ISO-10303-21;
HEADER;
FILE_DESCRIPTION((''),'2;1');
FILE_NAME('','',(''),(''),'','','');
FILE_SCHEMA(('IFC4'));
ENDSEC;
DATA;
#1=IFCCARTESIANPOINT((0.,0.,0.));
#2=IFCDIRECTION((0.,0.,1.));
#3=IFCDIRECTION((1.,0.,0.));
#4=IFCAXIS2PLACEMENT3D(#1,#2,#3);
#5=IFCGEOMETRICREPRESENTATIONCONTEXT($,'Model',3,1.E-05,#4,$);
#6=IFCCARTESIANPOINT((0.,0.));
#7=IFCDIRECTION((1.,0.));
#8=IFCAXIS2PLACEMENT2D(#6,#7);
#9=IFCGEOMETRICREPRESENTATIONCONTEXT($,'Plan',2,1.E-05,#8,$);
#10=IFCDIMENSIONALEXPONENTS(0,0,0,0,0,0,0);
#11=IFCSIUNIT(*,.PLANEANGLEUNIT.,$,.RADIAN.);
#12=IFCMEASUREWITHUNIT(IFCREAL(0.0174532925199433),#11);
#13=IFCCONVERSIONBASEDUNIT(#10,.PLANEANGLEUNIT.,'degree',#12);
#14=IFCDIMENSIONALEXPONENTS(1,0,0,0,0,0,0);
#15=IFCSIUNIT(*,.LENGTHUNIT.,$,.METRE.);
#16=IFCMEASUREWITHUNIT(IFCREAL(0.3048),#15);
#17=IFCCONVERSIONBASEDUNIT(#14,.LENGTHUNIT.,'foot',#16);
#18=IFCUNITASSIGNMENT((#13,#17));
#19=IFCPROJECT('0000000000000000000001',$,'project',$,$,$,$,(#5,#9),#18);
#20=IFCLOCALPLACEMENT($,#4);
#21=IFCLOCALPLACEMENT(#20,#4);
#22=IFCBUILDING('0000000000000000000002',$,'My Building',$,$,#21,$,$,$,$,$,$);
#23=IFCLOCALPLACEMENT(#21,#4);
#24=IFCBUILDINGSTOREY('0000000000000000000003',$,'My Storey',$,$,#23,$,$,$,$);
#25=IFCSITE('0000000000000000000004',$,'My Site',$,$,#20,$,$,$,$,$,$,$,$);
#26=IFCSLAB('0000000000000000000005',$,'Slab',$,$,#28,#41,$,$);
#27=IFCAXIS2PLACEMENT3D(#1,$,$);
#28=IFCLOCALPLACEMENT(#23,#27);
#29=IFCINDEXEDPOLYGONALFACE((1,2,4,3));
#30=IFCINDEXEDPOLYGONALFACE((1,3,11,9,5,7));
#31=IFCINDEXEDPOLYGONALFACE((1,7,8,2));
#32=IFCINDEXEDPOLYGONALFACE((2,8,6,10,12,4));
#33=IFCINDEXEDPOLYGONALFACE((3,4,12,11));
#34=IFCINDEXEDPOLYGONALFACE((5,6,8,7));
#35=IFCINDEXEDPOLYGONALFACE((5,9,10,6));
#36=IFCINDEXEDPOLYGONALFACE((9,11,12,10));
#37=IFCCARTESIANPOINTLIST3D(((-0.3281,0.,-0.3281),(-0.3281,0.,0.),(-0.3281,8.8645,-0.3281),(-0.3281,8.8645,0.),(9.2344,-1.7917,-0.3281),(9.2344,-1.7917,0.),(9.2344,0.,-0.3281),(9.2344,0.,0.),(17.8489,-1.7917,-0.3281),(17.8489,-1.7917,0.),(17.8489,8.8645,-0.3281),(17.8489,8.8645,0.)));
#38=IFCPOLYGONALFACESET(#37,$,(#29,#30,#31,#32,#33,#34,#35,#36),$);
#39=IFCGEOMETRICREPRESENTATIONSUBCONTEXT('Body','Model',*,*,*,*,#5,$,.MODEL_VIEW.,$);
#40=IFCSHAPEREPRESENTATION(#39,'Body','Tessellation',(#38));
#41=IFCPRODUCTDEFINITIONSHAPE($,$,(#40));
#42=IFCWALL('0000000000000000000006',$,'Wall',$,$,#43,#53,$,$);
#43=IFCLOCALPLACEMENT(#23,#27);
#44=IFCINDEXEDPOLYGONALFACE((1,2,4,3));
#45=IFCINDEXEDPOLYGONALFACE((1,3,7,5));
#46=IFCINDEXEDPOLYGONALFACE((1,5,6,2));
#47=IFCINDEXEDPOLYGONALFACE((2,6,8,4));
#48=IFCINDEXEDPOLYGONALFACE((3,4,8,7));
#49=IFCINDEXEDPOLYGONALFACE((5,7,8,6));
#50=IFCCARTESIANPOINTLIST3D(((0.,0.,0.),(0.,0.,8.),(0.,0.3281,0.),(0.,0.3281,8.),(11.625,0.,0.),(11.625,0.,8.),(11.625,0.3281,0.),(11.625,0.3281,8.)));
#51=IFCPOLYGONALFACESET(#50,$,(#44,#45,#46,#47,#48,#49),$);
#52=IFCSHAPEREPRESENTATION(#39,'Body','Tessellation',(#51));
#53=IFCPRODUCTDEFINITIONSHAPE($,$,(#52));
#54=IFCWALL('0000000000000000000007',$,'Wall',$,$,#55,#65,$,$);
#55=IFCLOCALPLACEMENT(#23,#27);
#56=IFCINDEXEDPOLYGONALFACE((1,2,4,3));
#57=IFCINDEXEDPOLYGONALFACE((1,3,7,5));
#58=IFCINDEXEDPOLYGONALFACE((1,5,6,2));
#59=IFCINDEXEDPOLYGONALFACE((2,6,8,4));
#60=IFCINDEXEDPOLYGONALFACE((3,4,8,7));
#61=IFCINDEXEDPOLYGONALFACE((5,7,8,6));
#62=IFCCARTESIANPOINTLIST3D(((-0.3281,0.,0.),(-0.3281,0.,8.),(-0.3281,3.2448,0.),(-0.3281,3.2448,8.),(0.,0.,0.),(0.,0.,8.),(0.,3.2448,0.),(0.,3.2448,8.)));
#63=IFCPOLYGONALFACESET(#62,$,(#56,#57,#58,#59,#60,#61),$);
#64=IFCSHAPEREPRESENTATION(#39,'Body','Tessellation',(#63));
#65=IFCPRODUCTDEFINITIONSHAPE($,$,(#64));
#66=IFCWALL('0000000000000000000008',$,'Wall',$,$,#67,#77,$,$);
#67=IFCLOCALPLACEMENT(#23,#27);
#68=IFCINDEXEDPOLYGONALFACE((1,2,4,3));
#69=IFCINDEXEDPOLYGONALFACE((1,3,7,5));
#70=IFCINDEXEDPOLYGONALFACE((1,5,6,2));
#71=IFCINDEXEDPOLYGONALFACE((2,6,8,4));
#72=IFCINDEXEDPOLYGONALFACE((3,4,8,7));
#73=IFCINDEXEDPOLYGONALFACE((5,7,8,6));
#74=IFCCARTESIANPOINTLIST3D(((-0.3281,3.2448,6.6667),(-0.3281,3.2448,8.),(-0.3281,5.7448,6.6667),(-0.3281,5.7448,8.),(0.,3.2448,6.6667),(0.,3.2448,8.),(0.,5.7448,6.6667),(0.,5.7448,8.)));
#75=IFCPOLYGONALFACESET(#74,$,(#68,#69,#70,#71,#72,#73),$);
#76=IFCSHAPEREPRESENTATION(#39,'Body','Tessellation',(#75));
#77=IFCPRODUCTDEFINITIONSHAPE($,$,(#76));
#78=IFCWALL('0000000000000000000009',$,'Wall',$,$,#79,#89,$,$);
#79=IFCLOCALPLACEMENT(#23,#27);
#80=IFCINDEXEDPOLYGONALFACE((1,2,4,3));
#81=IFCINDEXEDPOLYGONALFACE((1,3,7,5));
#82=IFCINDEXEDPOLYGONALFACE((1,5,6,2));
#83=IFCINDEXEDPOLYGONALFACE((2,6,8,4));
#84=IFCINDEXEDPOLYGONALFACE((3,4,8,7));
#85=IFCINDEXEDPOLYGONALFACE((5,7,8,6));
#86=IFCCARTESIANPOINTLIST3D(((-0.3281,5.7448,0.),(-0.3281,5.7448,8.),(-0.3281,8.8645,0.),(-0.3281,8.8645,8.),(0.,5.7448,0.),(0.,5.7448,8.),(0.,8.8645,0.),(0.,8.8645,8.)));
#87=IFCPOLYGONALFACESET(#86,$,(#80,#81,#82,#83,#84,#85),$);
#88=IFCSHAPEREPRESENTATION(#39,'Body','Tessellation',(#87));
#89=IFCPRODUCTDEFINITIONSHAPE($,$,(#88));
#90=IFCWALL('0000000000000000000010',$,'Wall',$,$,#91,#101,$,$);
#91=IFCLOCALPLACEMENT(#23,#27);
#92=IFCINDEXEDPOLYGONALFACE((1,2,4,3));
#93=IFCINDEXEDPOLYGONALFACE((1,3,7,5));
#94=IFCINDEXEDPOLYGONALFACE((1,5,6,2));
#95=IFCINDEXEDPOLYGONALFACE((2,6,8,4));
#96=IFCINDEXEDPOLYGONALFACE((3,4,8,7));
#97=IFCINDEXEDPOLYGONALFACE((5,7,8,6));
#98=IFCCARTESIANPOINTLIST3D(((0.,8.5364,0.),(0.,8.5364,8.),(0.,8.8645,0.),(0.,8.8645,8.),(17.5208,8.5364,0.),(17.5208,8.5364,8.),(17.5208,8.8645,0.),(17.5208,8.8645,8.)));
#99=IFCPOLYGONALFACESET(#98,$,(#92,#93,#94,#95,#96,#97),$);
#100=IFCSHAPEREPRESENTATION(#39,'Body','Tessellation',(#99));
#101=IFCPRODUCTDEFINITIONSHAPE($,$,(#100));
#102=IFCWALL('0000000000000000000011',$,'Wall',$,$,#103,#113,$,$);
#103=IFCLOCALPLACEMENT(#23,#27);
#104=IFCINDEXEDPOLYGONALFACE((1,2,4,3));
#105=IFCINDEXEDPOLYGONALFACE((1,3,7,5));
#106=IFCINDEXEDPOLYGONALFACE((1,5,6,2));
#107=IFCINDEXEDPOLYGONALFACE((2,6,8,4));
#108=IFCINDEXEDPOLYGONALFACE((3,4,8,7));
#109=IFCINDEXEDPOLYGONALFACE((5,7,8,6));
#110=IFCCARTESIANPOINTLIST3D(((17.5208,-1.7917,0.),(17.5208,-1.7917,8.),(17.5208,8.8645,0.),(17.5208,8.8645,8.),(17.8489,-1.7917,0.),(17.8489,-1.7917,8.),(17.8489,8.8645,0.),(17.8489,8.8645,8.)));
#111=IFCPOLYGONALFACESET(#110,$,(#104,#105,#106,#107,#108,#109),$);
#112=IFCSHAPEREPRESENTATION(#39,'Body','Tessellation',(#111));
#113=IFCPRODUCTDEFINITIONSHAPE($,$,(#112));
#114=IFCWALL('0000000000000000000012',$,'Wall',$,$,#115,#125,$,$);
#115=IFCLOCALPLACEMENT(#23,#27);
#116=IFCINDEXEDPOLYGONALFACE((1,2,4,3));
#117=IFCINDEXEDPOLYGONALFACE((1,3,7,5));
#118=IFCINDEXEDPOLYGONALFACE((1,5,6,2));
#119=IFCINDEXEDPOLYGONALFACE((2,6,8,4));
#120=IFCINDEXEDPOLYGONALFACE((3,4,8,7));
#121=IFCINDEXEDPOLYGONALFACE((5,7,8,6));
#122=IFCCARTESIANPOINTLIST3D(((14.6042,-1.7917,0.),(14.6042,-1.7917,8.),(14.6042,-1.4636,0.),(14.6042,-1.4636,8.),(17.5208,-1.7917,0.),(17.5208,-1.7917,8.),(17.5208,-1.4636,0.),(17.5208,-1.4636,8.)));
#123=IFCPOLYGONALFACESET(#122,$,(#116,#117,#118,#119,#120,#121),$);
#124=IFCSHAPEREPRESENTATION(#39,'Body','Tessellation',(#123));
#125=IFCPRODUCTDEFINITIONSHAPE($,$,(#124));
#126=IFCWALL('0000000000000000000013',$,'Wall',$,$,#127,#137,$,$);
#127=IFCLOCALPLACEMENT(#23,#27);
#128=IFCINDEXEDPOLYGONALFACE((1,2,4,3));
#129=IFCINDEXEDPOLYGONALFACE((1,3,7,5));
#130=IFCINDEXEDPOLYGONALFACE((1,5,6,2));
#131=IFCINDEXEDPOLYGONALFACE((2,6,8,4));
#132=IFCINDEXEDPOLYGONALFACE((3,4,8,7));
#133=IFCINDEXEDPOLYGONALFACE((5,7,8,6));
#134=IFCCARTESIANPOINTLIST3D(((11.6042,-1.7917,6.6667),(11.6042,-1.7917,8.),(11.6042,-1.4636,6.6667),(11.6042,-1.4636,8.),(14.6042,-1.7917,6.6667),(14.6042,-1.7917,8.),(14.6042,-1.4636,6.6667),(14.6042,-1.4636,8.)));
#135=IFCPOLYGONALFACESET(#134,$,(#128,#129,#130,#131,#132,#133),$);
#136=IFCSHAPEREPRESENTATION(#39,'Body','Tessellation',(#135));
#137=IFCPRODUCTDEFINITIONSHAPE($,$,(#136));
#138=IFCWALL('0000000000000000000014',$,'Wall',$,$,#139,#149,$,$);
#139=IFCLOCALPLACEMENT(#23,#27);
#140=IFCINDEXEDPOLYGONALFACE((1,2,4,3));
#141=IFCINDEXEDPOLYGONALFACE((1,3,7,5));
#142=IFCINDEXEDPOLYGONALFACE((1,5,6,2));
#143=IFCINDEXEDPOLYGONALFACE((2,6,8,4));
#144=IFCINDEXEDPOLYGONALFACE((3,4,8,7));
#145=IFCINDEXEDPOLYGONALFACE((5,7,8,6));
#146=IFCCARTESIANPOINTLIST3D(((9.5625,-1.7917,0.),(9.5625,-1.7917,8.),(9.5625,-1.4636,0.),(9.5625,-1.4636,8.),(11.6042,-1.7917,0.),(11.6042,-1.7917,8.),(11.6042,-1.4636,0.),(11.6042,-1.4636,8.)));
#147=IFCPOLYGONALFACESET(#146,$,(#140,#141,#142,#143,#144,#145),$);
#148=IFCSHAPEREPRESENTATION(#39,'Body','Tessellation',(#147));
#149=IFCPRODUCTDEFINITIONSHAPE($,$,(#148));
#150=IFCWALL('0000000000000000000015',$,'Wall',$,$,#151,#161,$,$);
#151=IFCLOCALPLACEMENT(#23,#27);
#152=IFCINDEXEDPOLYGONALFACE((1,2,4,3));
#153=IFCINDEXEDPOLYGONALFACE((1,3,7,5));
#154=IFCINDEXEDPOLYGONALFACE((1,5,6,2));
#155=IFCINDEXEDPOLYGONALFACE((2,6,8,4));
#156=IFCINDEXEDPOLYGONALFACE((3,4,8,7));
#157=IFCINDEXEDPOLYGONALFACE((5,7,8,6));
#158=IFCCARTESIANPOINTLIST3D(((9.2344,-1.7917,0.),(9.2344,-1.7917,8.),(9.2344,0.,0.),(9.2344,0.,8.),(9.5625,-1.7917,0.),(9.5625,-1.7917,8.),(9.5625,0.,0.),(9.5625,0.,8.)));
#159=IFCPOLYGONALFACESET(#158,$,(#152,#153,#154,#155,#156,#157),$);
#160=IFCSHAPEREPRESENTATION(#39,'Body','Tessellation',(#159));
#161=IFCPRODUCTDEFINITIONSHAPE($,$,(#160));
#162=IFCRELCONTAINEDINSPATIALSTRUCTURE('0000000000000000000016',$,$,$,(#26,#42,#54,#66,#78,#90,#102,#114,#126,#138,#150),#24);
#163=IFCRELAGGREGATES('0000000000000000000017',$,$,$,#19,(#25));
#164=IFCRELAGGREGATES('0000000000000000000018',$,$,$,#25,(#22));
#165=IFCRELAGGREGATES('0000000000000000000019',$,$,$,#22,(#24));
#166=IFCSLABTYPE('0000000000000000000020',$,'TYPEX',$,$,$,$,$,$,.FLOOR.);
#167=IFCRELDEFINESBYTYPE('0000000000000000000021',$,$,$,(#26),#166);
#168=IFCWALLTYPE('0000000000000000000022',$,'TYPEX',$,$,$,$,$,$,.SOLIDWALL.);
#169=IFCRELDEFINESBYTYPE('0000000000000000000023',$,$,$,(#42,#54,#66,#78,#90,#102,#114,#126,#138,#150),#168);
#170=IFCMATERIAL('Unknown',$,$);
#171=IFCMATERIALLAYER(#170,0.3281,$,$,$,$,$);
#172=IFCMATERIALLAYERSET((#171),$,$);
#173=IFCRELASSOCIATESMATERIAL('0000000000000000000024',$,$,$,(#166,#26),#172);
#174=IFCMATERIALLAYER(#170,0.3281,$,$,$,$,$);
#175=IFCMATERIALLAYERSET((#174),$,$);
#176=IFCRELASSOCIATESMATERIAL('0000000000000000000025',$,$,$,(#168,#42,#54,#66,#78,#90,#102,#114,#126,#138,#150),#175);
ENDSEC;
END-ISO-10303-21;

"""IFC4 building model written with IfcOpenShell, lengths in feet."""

from ifc_helpers import new_model, entity, si_unit, converted_unit, frame, origin_with_axes, origin_2d_with_axis, place, context, subcontext, project, spatial, line, indexed_curve, outline, extrude, material, layer, layer_set, layer_usage, type_object, element, save


model = new_model("IFC4")

# Units and contexts
model_context = context("Model", 3, precision=1e-05, world=origin_with_axes())
plan_context = context("Plan", 2, precision=1e-05, world=origin_2d_with_axis())
body_context = subcontext(model_context, "Body", "Model", "MODEL_VIEW")
ifc_project = project(units=[converted_unit("PLANEANGLEUNIT", "degree", entity("IfcReal", 0.0174532925199433), si_unit("PLANEANGLEUNIT", "RADIAN"), dimensions=[0, 0, 0, 0, 0, 0, 0]), converted_unit("LENGTHUNIT", "foot", entity("IfcReal", 0.3048), si_unit("LENGTHUNIT", "METRE"), dimensions=[1, 0, 0, 0, 0, 0, 0])], contexts=[model_context, plan_context])

# Site, building, storey
site_placement = place(None, origin_with_axes())
site = spatial("IfcSite", under=ifc_project, at=site_placement, Name="My Site")
building_placement = place(site_placement, origin_with_axes())
building = spatial("IfcBuilding", under=site, at=building_placement, Name="My Building")
storey_placement = place(building_placement, origin_with_axes())
storey = spatial("IfcBuildingStorey", under=building, at=storey_placement, Name="My Storey")

# Slab
ifc_material = material(Name="Unknown")
ifc_layer_1 = layer(ifc_material, 0.3281)
ifc_layer_set_1 = layer_set([ifc_layer_1])
ifc_layer_usage_1 = layer_usage(ifc_layer_set_1, "AXIS3", "POSITIVE", 0.0)
slab_type = type_object("IfcSlabType", Name="TYPEX", PredefinedType="FLOOR", material=ifc_layer_set_1)
slab_placement = place(storey_placement, frame((-0.3281, 0.0, -0.3281), z_axis=(0.0, 0.0, 1.0), x_axis=(1.0, 0.0, 0.0)))
element("IfcSlab", 1, at=slab_placement, inside=storey, type_object=slab_type, material=ifc_layer_usage_1, Name="Slab", context=body_context, shape_type="SweptSolid", body=[
    extrude(outline(indexed_curve([(0.0, 0.0), (9.5625, 0.0), (18.177, 8.8645), (0.0, 8.8645), (18.177, -1.7917), (9.5625, -1.7917)], segments=[line(5, 3), line(3, 4), line(4, 1), line(1, 2), line(2, 6), line(6, 5)], self_intersect=False)), None, (0.0, 0.0, 1.0), 0.3281),
])

# Walls
ifc_layer_2 = layer(ifc_material, 0.3281)
ifc_layer_set_2 = layer_set([ifc_layer_2])
ifc_layer_usage_2 = layer_usage(ifc_layer_set_2, "AXIS2", "POSITIVE", 0.0)
wall_type = type_object("IfcWallType", Name="TYPEX", PredefinedType="SOLIDWALL", material=ifc_layer_set_2)
wall_1_placement = place(storey_placement, origin_with_axes())
element("IfcWall", 2, at=wall_1_placement, inside=storey, type_object=wall_type, material=ifc_layer_usage_2, Name="Wall", context=body_context, shape_type="SweptSolid", body=[
    extrude(outline(indexed_curve([(0.0, 0.0), (0.0, 0.3281), (11.625, 0.3281), (11.625, 0.0), (0.0, 0.0)], self_intersect=False)), origin_with_axes(), (0.0, 0.0, 1.0), 8.0),
])
ifc_layer_usage_3 = layer_usage(ifc_layer_set_2, "AXIS2", "POSITIVE", 0.0)
wall_2_placement = place(storey_placement, frame((0.0, 0.0, 0.0), z_axis=(0.0, 0.0, 1.0), x_axis=(0.000001, 1.0, 0.0)))
element("IfcWall", 3, at=wall_2_placement, inside=storey, type_object=wall_type, material=ifc_layer_usage_3, Name="Wall", context=body_context, shape_type="SweptSolid", body=[
    extrude(outline(indexed_curve([(0.0, 0.0), (0.0, 0.3281), (3.2448, 0.3281), (3.2448, 0.0), (0.0, 0.0)], self_intersect=False)), origin_with_axes(), (0.0, 0.0, 1.0), 8.0),
])
ifc_layer_usage_4 = layer_usage(ifc_layer_set_2, "AXIS2", "POSITIVE", 0.0)
wall_3_placement = place(storey_placement, frame((-0.3281, 5.7448, 6.6667), z_axis=(0.0, 0.0, 1.0), x_axis=(-0.000001, -1.0, 0.0)))
element("IfcWall", 4, at=wall_3_placement, inside=storey, type_object=wall_type, material=ifc_layer_usage_4, Name="Wall", context=body_context, shape_type="SweptSolid", body=[
    extrude(outline(indexed_curve([(0.0, 0.0), (0.0, 0.3281), (2.5, 0.3281), (2.5, 0.0), (0.0, 0.0)], self_intersect=False)), origin_with_axes(), (0.0, 0.0, 1.0), 1.3333),
])
ifc_layer_usage_5 = layer_usage(ifc_layer_set_2, "AXIS2", "POSITIVE", 0.0)
wall_4_placement = place(storey_placement, frame((-0.3281, 8.8645, 0.0), z_axis=(0.0, 0.0, 1.0), x_axis=(-0.000001, -1.0, 0.0)))
element("IfcWall", 5, at=wall_4_placement, inside=storey, type_object=wall_type, material=ifc_layer_usage_5, Name="Wall", context=body_context, shape_type="SweptSolid", body=[
    extrude(outline(indexed_curve([(0.0, 0.0), (0.0, 0.3281), (3.1198, 0.3281), (3.1198, 0.0), (0.0, 0.0)], self_intersect=False)), origin_with_axes(), (0.0, 0.0, 1.0), 8.0),
])
ifc_layer_usage_6 = layer_usage(ifc_layer_set_2, "AXIS2", "POSITIVE", 0.0)
wall_5_placement = place(storey_placement, frame((0.0, 8.5364, 0.0), z_axis=(0.0, 0.0, 1.0), x_axis=(1.0, -0.000001, 0.0)))
element("IfcWall", 6, at=wall_5_placement, inside=storey, type_object=wall_type, material=ifc_layer_usage_6, Name="Wall", context=body_context, shape_type="SweptSolid", body=[
    extrude(outline(indexed_curve([(0.0, 0.0), (0.0, 0.3281), (17.5208, 0.3281), (17.5208, 0.0), (0.0, 0.0)], self_intersect=False)), origin_with_axes(), (0.0, 0.0, 1.0), 8.0),
])
ifc_layer_usage_7 = layer_usage(ifc_layer_set_2, "AXIS2", "POSITIVE", 0.0)
wall_6_placement = place(storey_placement, frame((17.5208, 8.8645, 0.0), z_axis=(0.0, 0.0, 1.0), x_axis=(-0.000001, -1.0, 0.0)))
element("IfcWall", 7, at=wall_6_placement, inside=storey, type_object=wall_type, material=ifc_layer_usage_7, Name="Wall", context=body_context, shape_type="SweptSolid", body=[
    extrude(outline(indexed_curve([(0.0, 0.0), (0.0, 0.3281), (10.6562, 0.3281), (10.6562, 0.0), (0.0, 0.0)], self_intersect=False)), origin_with_axes(), (0.0, 0.0, 1.0), 8.0),
])
ifc_layer_usage_8 = layer_usage(ifc_layer_set_2, "AXIS2", "POSITIVE", 0.0)
wall_7_placement = place(storey_placement, frame((17.5208, -1.4636, 0.0), z_axis=(0.0, 0.0, 1.0), x_axis=(-1.0, 0.000002, 0.0)))
element("IfcWall", 8, at=wall_7_placement, inside=storey, type_object=wall_type, material=ifc_layer_usage_8, Name="Wall", context=body_context, shape_type="SweptSolid", body=[
    extrude(outline(indexed_curve([(0.0, 0.0), (0.0, 0.3281), (2.9167, 0.3281), (2.9167, 0.0), (0.0, 0.0)], self_intersect=False)), origin_with_axes(), (0.0, 0.0, 1.0), 8.0),
])
ifc_layer_usage_9 = layer_usage(ifc_layer_set_2, "AXIS2", "POSITIVE", 0.0)
wall_8_placement = place(storey_placement, frame((11.6042, -1.7917, 6.6667), z_axis=(0.0, 0.0, 1.0), x_axis=(1.0, -0.000002, 0.0)))
element("IfcWall", 9, at=wall_8_placement, inside=storey, type_object=wall_type, material=ifc_layer_usage_9, Name="Wall", context=body_context, shape_type="SweptSolid", body=[
    extrude(outline(indexed_curve([(0.0, 0.0), (0.0, 0.3281), (3.0, 0.3281), (3.0, 0.0), (0.0, 0.0)], self_intersect=False)), origin_with_axes(), (0.0, 0.0, 1.0), 1.3333),
])
ifc_layer_usage_10 = layer_usage(ifc_layer_set_2, "AXIS2", "POSITIVE", 0.0)
wall_9_placement = place(storey_placement, frame((9.5625, -1.7917, 0.0), z_axis=(0.0, 0.0, 1.0), x_axis=(1.0, -0.000002, 0.0)))
element("IfcWall", 10, at=wall_9_placement, inside=storey, type_object=wall_type, material=ifc_layer_usage_10, Name="Wall", context=body_context, shape_type="SweptSolid", body=[
    extrude(outline(indexed_curve([(0.0, 0.0), (0.0, 0.3281), (2.0417, 0.3281), (2.0417, 0.0), (0.0, 0.0)], self_intersect=False)), origin_with_axes(), (0.0, 0.0, 1.0), 8.0),
])
ifc_layer_usage_11 = layer_usage(ifc_layer_set_2, "AXIS2", "POSITIVE", 0.0)
wall_10_placement = place(storey_placement, frame((9.5625, -1.7917, 0.0), z_axis=(0.0, 0.0, 1.0), x_axis=(0.000003, 1.0, 0.0)))
element("IfcWall", 11, at=wall_10_placement, inside=storey, type_object=wall_type, material=ifc_layer_usage_11, Name="Wall", context=body_context, shape_type="SweptSolid", body=[
    extrude(outline(indexed_curve([(0.0, 0.0), (0.0, 0.3281), (1.7917, 0.3281), (1.7917, 0.0), (0.0, 0.0)], self_intersect=False)), origin_with_axes(), (0.0, 0.0, 1.0), 8.0),
])

save(model, "model.ifc")
